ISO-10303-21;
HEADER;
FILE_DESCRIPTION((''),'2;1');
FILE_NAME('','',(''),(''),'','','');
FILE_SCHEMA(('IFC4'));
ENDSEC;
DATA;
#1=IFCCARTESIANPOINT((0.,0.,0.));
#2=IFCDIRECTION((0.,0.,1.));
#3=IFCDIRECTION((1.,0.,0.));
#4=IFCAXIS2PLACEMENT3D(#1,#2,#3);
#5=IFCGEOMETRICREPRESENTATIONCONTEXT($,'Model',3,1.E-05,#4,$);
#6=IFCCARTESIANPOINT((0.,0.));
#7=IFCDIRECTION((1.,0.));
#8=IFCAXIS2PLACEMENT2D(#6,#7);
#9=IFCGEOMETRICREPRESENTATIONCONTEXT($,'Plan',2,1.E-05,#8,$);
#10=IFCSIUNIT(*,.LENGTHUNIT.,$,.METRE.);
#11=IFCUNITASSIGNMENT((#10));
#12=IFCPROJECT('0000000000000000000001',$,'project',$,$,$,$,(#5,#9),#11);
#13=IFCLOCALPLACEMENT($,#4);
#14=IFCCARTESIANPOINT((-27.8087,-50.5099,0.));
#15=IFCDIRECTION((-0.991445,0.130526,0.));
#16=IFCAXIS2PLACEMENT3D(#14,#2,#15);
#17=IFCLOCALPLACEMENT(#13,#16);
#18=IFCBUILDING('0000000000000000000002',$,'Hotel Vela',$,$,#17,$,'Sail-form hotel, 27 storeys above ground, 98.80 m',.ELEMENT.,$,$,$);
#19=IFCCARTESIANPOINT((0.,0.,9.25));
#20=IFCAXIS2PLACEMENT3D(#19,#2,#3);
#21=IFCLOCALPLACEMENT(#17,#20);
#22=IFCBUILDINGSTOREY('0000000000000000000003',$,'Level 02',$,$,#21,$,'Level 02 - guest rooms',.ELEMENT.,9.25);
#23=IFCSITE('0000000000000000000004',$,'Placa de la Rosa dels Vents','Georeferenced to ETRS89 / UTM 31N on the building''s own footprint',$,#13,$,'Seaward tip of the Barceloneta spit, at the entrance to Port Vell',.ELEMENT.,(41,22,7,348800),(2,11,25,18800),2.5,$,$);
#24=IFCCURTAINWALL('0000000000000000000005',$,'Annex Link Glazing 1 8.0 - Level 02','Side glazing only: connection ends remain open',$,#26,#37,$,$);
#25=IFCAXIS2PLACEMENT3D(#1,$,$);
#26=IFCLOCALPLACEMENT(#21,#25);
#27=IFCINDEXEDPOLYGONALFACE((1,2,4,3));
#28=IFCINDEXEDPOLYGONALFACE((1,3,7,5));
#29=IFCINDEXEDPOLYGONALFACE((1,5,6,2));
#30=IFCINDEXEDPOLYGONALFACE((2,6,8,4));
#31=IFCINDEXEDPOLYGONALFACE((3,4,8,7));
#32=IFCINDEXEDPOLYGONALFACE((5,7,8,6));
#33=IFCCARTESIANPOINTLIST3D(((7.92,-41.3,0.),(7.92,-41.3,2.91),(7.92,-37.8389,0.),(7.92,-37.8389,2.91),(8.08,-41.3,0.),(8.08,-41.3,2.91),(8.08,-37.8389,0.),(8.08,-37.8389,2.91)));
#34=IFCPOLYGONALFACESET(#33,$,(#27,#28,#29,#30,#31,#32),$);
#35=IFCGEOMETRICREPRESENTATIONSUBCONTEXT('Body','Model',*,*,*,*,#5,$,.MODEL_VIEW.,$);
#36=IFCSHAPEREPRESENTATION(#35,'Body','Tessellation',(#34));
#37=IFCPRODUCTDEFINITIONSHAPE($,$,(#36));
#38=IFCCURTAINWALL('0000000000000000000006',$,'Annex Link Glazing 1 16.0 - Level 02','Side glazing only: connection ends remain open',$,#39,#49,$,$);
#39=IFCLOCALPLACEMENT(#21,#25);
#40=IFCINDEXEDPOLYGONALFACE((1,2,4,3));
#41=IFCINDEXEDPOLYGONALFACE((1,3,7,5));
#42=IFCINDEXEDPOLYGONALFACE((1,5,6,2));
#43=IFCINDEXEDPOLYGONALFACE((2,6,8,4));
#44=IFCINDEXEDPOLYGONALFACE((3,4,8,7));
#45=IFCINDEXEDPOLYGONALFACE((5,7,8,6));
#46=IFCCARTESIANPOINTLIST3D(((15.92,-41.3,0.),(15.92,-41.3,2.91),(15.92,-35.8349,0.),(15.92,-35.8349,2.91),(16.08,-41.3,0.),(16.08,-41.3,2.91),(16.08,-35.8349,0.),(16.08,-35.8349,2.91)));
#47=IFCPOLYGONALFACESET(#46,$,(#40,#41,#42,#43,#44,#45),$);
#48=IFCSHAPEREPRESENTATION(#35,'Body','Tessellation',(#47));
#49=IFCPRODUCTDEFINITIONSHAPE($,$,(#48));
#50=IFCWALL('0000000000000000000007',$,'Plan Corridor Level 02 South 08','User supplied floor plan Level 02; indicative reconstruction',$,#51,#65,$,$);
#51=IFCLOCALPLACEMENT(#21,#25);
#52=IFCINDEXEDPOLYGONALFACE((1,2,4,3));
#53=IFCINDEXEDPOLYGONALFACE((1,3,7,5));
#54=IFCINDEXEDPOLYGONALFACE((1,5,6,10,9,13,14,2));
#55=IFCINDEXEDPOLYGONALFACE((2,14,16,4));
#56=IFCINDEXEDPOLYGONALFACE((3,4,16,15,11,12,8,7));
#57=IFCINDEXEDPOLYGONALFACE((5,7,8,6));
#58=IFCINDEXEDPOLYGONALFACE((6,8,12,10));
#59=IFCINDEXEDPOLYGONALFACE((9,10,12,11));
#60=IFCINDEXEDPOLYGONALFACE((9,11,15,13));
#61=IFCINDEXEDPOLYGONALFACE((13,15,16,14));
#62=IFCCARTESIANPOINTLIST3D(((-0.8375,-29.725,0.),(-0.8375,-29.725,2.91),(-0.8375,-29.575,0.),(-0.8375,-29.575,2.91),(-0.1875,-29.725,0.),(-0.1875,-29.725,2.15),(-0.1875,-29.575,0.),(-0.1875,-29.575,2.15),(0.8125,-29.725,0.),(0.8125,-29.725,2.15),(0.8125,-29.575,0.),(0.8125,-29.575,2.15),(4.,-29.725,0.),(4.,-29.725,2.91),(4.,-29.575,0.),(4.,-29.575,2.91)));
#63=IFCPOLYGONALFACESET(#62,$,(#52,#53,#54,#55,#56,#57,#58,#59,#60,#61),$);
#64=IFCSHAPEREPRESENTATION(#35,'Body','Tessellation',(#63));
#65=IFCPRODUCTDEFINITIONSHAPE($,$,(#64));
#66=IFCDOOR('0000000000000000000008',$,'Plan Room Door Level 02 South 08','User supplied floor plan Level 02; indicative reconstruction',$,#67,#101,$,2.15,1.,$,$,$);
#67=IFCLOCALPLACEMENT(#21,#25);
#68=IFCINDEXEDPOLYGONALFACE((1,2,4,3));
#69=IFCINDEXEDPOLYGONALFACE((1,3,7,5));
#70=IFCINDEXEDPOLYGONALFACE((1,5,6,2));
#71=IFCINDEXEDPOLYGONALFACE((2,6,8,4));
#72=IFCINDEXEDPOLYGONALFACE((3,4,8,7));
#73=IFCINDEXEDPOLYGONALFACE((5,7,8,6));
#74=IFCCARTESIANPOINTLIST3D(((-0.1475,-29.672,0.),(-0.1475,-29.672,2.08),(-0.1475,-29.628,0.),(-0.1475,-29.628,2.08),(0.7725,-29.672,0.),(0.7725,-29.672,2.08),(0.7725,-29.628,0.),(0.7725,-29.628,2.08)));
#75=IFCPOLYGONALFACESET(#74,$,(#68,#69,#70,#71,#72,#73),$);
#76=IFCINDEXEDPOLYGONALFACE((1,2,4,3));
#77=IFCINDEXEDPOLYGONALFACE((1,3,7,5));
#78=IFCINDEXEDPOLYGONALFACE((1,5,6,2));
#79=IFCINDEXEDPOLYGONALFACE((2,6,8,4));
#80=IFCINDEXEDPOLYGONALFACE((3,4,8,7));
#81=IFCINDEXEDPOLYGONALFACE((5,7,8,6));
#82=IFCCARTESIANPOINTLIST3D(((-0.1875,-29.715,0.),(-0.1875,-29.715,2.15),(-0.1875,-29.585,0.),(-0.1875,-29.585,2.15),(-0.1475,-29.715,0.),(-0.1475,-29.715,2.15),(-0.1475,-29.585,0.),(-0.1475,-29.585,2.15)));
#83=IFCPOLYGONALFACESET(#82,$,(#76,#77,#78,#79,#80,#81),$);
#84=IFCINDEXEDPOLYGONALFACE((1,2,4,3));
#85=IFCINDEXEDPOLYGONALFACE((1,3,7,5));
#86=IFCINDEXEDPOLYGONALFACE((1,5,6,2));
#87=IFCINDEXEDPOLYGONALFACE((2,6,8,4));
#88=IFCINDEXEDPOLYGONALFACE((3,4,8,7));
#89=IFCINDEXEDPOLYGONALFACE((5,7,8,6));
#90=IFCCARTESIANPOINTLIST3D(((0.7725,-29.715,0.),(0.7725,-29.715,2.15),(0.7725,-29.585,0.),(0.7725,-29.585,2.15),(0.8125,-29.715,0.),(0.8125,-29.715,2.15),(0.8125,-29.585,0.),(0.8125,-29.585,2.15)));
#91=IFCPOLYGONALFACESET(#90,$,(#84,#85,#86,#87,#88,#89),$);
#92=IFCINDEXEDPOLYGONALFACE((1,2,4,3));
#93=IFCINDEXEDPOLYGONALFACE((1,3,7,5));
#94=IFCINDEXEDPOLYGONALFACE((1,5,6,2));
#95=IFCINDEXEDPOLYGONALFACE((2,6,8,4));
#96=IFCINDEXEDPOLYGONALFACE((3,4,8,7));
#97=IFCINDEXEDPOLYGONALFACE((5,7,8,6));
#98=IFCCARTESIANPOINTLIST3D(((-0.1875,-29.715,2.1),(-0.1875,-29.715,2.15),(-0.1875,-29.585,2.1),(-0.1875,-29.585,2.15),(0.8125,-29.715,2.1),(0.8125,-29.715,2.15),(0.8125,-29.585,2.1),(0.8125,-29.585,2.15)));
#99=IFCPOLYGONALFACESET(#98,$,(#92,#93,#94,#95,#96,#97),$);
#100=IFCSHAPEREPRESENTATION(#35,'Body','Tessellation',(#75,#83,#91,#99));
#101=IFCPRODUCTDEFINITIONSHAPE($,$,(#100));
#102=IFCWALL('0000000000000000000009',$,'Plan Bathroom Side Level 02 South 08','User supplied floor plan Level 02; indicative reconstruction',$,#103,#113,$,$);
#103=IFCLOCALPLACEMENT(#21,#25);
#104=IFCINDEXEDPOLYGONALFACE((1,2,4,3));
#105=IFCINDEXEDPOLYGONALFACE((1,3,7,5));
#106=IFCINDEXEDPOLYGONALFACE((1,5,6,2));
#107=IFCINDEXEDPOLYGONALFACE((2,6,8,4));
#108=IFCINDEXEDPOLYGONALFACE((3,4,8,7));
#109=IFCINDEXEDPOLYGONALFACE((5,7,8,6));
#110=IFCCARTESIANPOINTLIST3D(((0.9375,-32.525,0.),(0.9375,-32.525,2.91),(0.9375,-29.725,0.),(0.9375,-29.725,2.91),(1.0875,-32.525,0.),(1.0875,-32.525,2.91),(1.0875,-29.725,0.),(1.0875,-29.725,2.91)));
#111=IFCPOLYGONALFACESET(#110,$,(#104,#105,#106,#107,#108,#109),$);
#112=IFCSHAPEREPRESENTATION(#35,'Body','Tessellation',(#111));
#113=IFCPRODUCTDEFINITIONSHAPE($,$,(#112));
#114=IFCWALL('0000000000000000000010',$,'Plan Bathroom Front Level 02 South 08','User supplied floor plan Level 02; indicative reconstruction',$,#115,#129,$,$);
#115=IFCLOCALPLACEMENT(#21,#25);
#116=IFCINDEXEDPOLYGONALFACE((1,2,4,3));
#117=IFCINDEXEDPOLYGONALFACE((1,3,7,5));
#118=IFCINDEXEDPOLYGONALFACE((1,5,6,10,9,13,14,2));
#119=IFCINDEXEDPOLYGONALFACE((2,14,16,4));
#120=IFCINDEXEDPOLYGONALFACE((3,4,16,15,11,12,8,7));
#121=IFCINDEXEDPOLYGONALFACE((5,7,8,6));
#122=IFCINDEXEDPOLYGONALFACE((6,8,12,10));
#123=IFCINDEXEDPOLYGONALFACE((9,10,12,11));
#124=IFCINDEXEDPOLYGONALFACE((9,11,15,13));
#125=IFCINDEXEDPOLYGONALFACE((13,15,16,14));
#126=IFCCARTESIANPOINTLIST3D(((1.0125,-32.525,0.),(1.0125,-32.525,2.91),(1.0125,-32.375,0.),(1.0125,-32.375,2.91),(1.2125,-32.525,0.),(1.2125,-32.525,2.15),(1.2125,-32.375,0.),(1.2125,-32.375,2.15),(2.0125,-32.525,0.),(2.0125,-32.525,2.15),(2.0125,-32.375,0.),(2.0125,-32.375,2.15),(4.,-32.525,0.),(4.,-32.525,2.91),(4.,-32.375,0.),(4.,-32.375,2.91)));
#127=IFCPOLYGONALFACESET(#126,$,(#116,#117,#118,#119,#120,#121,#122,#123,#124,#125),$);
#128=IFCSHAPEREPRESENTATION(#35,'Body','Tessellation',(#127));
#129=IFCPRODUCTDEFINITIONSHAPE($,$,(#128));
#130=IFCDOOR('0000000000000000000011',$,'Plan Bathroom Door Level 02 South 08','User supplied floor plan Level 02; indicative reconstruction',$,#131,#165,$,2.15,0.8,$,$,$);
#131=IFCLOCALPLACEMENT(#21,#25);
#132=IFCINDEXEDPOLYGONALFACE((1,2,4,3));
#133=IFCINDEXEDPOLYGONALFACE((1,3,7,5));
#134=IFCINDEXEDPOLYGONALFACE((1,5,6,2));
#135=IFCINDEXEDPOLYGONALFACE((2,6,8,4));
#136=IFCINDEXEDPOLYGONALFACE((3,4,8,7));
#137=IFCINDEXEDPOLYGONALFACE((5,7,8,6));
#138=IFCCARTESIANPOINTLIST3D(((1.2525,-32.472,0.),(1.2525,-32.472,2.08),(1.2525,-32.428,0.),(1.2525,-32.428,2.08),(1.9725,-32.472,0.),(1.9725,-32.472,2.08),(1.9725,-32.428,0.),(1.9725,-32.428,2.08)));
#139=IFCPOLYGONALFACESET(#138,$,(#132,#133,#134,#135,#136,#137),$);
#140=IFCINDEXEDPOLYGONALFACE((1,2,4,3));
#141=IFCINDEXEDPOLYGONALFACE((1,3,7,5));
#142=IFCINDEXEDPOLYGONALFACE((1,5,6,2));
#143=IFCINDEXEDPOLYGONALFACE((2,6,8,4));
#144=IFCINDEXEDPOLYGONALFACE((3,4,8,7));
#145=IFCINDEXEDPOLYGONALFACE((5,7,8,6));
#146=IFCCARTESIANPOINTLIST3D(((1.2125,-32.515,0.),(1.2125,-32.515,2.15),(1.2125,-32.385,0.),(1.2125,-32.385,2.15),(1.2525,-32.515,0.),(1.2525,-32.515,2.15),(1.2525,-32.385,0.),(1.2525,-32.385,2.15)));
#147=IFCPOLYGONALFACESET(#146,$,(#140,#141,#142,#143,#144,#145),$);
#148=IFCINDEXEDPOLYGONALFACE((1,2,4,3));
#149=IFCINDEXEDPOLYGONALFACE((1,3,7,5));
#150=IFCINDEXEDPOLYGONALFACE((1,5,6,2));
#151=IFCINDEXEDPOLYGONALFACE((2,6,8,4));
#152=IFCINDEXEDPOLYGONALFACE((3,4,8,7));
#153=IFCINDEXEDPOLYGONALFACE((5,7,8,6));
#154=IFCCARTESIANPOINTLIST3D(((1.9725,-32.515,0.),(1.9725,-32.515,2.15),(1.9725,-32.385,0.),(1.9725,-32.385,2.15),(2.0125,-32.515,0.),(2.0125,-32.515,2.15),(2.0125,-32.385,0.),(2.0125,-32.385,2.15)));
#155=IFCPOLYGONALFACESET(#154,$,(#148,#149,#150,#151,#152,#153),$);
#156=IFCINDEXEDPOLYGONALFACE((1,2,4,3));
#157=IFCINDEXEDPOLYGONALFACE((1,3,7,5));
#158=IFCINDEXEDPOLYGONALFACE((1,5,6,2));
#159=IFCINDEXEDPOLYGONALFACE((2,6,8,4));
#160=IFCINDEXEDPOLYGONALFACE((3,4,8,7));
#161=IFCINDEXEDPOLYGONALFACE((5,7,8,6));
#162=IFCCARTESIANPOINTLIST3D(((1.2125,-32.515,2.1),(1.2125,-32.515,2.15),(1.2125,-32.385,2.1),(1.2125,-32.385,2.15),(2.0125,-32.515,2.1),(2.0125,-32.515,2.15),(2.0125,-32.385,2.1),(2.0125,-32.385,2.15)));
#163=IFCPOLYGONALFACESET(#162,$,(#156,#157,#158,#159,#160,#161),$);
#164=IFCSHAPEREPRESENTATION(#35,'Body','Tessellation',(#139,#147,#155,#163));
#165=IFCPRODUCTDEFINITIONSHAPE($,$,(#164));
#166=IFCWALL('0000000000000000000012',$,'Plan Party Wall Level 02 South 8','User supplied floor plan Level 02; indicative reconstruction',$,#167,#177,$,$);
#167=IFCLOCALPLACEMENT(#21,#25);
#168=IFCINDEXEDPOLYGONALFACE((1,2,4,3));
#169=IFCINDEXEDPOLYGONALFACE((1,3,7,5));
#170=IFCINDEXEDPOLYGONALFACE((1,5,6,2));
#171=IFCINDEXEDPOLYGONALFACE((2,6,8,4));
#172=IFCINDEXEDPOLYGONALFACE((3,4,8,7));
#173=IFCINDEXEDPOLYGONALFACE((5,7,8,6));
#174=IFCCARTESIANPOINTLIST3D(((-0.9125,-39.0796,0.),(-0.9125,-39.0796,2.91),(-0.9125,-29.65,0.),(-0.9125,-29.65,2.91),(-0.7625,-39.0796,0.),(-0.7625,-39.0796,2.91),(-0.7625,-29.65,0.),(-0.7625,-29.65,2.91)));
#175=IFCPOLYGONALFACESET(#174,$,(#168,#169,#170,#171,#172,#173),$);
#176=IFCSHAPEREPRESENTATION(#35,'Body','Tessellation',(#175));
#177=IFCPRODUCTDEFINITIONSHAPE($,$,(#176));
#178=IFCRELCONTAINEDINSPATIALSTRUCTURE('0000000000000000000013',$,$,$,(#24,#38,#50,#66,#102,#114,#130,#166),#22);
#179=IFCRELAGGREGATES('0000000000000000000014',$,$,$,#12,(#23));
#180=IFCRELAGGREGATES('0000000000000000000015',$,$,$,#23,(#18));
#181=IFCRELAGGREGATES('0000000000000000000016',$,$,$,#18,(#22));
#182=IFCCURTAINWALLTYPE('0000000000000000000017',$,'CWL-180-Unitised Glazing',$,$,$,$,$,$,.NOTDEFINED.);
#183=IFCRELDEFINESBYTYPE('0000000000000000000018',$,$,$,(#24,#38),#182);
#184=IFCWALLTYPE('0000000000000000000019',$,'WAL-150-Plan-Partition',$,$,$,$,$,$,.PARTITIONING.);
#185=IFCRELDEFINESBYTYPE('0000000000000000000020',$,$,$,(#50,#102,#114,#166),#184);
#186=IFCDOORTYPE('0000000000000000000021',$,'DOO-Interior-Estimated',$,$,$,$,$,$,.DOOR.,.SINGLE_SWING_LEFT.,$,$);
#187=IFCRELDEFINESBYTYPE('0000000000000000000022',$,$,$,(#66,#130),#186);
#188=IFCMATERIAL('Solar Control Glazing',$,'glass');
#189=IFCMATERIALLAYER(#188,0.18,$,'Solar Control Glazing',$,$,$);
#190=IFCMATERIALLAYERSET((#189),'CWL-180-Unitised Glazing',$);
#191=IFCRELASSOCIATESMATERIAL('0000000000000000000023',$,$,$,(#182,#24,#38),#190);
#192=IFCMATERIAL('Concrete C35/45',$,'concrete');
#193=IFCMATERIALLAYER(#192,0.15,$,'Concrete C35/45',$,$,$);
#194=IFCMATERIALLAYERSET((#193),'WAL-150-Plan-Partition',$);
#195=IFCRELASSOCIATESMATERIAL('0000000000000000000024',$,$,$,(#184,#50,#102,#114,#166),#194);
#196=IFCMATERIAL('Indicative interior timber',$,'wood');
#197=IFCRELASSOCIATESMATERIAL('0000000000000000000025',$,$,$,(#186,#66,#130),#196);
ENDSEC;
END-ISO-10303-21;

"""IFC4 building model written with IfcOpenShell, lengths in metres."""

from ifc_helpers import new_model, si_unit, frame, origin_with_axes, origin_2d_with_axis, place, context, subcontext, project, spatial, line, indexed_curve, outline, extrude, material, layer, layer_set, layer_usage, type_object, element, fill, save


model = new_model("IFC4")

# Units and contexts
model_context = context("Model", 3, precision=1e-05, world=origin_with_axes())
plan_context = context("Plan", 2, precision=1e-05, world=origin_2d_with_axis())
body_context = subcontext(model_context, "Body", "Model", "MODEL_VIEW")
ifc_project = project(units=[si_unit("LENGTHUNIT", "METRE")], contexts=[model_context, plan_context])

# Site, building, storey
site_placement = place(None, origin_with_axes())
site = spatial("IfcSite", under=ifc_project, at=site_placement, Name="Placa de la Rosa dels Vents", Description="Georeferenced to ETRS89 / UTM 31N on the building's own footprint", LongName="Seaward tip of the Barceloneta spit, at the entrance to Port Vell", CompositionType="ELEMENT", RefLatitude=(41, 22, 7, 348800), RefLongitude=(2, 11, 25, 18800), RefElevation=2.5)
building_placement = place(site_placement, frame((-27.8087, -50.5099, 0.0), z_axis=(0.0, 0.0, 1.0), x_axis=(-0.991445, 0.130526, 0.0)))
building = spatial("IfcBuilding", under=site, at=building_placement, Name="Hotel Vela", LongName="Sail-form hotel, 27 storeys above ground, 98.80 m", CompositionType="ELEMENT")
storey_placement = place(building_placement, frame((0.0, 0.0, 9.25), z_axis=(0.0, 0.0, 1.0), x_axis=(1.0, 0.0, 0.0)))
storey = spatial("IfcBuildingStorey", under=building, at=storey_placement, Name="Level 02", LongName="Level 02 - guest rooms", CompositionType="ELEMENT", Elevation=9.25)

# Curtain walls
ifc_material_1 = material(Name="Solar Control Glazing", Category="glass")
ifc_layer_1 = layer(ifc_material_1, 0.18, Name="Solar Control Glazing")
ifc_layer_set_1 = layer_set([ifc_layer_1], Name="CWL-180-Unitised Glazing")
ifc_layer_usage_1 = layer_usage(ifc_layer_set_1, "AXIS2", "POSITIVE", 0.0)
curtain_wall_type = type_object("IfcCurtainWallType", Name="CWL-180-Unitised Glazing", PredefinedType="NOTDEFINED", material=ifc_layer_set_1)
curtain_wall_1_placement = place(storey_placement, frame((7.92, -41.3, 0.0), z_axis=(0.0, 0.0, 1.0), x_axis=(1.0, 0.0, 0.0)))
element("IfcCurtainWall", 1, at=curtain_wall_1_placement, inside=storey, type_object=curtain_wall_type, material=ifc_layer_usage_1, Name="Annex Link Glazing 1 8.0 - Level 02", Description="Side glazing only: connection ends remain open", context=body_context, shape_type="SweptSolid", body=[
    extrude(outline(indexed_curve([(0.0, 0.0), (0.16, 0.0), (0.16, 3.4611), (0.0, 3.4611)], segments=[line(1, 2, 3, 4, 1)])), origin_with_axes(), (0.0, 0.0, 1.0), 2.91),
])
ifc_layer_usage_2 = layer_usage(ifc_layer_set_1, "AXIS2", "POSITIVE", 0.0)
curtain_wall_2_placement = place(storey_placement, frame((15.92, -41.3, 0.0), z_axis=(0.0, 0.0, 1.0), x_axis=(1.0, 0.0, 0.0)))
element("IfcCurtainWall", 2, at=curtain_wall_2_placement, inside=storey, type_object=curtain_wall_type, material=ifc_layer_usage_2, Name="Annex Link Glazing 1 16.0 - Level 02", Description="Side glazing only: connection ends remain open", context=body_context, shape_type="SweptSolid", body=[
    extrude(outline(indexed_curve([(0.0, 0.0), (0.16, 0.0), (0.16, 5.4651), (0.0, 5.4651)], segments=[line(1, 2, 3, 4, 1)])), origin_with_axes(), (0.0, 0.0, 1.0), 2.91),
])

# Wall, opening, door
ifc_material_2 = material(Name="Concrete C35/45", Category="concrete")
ifc_layer_2 = layer(ifc_material_2, 0.15, Name="Concrete C35/45")
ifc_layer_set_2 = layer_set([ifc_layer_2], Name="WAL-150-Plan-Partition")
ifc_layer_usage_3 = layer_usage(ifc_layer_set_2, "AXIS2", "POSITIVE", 0.0)
wall_type = type_object("IfcWallType", Name="WAL-150-Plan-Partition", PredefinedType="PARTITIONING", material=ifc_layer_set_2)
wall_1_placement = place(storey_placement, frame((-0.8375, -29.725, 0.0), z_axis=(0.0, 0.0, 1.0), x_axis=(1.0, 0.0, 0.0)))
wall_1 = element("IfcWall", 3, at=wall_1_placement, inside=storey, type_object=wall_type, material=ifc_layer_usage_3, Name="Plan Corridor Level 02 South 08", Description="User supplied floor plan Level 02; indicative reconstruction", context=body_context, shape_type="SweptSolid", body=[
    extrude(outline(indexed_curve([(0.0, 0.0), (4.8375, 0.0), (4.8375, 0.15), (0.0, 0.15)], segments=[line(1, 2, 3, 4, 1)])), origin_with_axes(), (0.0, 0.0, 1.0), 2.91),
])
opening_1_placement = place(wall_1_placement, frame((0.65, -0.085, 0.0), z_axis=(0.0, 0.0, 1.0), x_axis=(1.0, 0.0, 0.0)))
opening_1 = element("IfcOpeningElement", 4, at=opening_1_placement, cuts=wall_1, PredefinedType="OPENING", context=body_context, shape_type="SweptSolid", body=[
    extrude(outline(indexed_curve([(0.0, 0.0), (1.0, 0.0), (1.0, 0.32), (0.0, 0.32)], segments=[line(1, 2, 3, 4, 1)])), origin_with_axes(), (0.0, 0.0, 1.0), 2.15),
])
ifc_material_3 = material(Name="Indicative interior timber", Category="wood")
door_type = type_object("IfcDoorType", Name="DOO-Interior-Estimated", OperationType="SINGLE_SWING_LEFT", PredefinedType="DOOR", material=ifc_material_3)
door_1_placement = place(storey_placement, frame((0.0, 0.0, -9.25), z_axis=(0.0, 0.0, 1.0), x_axis=(1.0, 0.0, 0.0)))
door_1 = element("IfcDoor", 5, at=door_1_placement, inside=storey, type_object=door_type, material=ifc_material_3, Name="Plan Room Door Level 02 South 08", Description="User supplied floor plan Level 02; indicative reconstruction", OverallHeight=2.15, OverallWidth=1.0, context=body_context, shape_type="SweptSolid", body=[
    extrude(outline(indexed_curve([(0.0, 0.0), (0.92, 0.0), (0.92, 0.044), (0.0, 0.044)], segments=[line(1, 2, 3, 4, 1)])), frame((-0.1475, -29.672, 9.25), z_axis=(0.0, 0.0, 1.0), x_axis=(1.0, 0.0, 0.0)), (0.0, 0.0, 1.0), 2.08),
    extrude(outline(indexed_curve([(0.0, 0.0), (0.04, 0.0), (0.04, 0.13), (0.0, 0.13)], segments=[line(1, 2, 3, 4, 1)])), frame((-0.1875, -29.715, 9.25), z_axis=(0.0, 0.0, 1.0), x_axis=(1.0, 0.0, 0.0)), (0.0, 0.0, 1.0), 2.15),
    extrude(outline(indexed_curve([(0.0, 0.0), (0.04, 0.0), (0.04, 0.13), (0.0, 0.13)], segments=[line(1, 2, 3, 4, 1)])), frame((0.7725, -29.715, 9.25), z_axis=(0.0, 0.0, 1.0), x_axis=(1.0, 0.0, 0.0)), (0.0, 0.0, 1.0), 2.15),
    extrude(outline(indexed_curve([(0.0, 0.0), (1.0, 0.0), (1.0, 0.13), (0.0, 0.13)], segments=[line(1, 2, 3, 4, 1)])), frame((-0.1875, -29.715, 11.35), z_axis=(0.0, 0.0, 1.0), x_axis=(1.0, 0.0, 0.0)), (0.0, 0.0, 1.0), 0.05),
])
fill(opening_1, door_1)

# Wall
ifc_layer_usage_4 = layer_usage(ifc_layer_set_2, "AXIS2", "POSITIVE", 0.0)
wall_2_placement = place(storey_placement, frame((0.9375, -32.525, 0.0), z_axis=(0.0, 0.0, 1.0), x_axis=(1.0, 0.0, 0.0)))
element("IfcWall", 6, at=wall_2_placement, inside=storey, type_object=wall_type, material=ifc_layer_usage_4, Name="Plan Bathroom Side Level 02 South 08", Description="User supplied floor plan Level 02; indicative reconstruction", context=body_context, shape_type="SweptSolid", body=[
    extrude(outline(indexed_curve([(0.0, 0.0), (0.15, 0.0), (0.15, 2.8), (0.0, 2.8)], segments=[line(1, 2, 3, 4, 1)])), origin_with_axes(), (0.0, 0.0, 1.0), 2.91),
])

# Wall, opening, door
ifc_layer_usage_5 = layer_usage(ifc_layer_set_2, "AXIS2", "POSITIVE", 0.0)
wall_3_placement = place(storey_placement, frame((1.0125, -32.525, 0.0), z_axis=(0.0, 0.0, 1.0), x_axis=(1.0, 0.0, 0.0)))
wall_3 = element("IfcWall", 7, at=wall_3_placement, inside=storey, type_object=wall_type, material=ifc_layer_usage_5, Name="Plan Bathroom Front Level 02 South 08", Description="User supplied floor plan Level 02; indicative reconstruction", context=body_context, shape_type="SweptSolid", body=[
    extrude(outline(indexed_curve([(0.0, 0.0), (2.9875, 0.0), (2.9875, 0.15), (0.0, 0.15)], segments=[line(1, 2, 3, 4, 1)])), origin_with_axes(), (0.0, 0.0, 1.0), 2.91),
])
opening_2_placement = place(wall_3_placement, frame((0.2, -0.085, 0.0), z_axis=(0.0, 0.0, 1.0), x_axis=(1.0, 0.0, 0.0)))
opening_2 = element("IfcOpeningElement", 8, at=opening_2_placement, cuts=wall_3, PredefinedType="OPENING", context=body_context, shape_type="SweptSolid", body=[
    extrude(outline(indexed_curve([(0.0, 0.0), (0.8, 0.0), (0.8, 0.32), (0.0, 0.32)], segments=[line(1, 2, 3, 4, 1)])), origin_with_axes(), (0.0, 0.0, 1.0), 2.15),
])
door_2_placement = place(storey_placement, frame((0.0, 0.0, -9.25), z_axis=(0.0, 0.0, 1.0), x_axis=(1.0, 0.0, 0.0)))
door_2 = element("IfcDoor", 9, at=door_2_placement, inside=storey, type_object=door_type, material=ifc_material_3, Name="Plan Bathroom Door Level 02 South 08", Description="User supplied floor plan Level 02; indicative reconstruction", OverallHeight=2.15, OverallWidth=0.8, context=body_context, shape_type="SweptSolid", body=[
    extrude(outline(indexed_curve([(0.0, 0.0), (0.72, 0.0), (0.72, 0.044), (0.0, 0.044)], segments=[line(1, 2, 3, 4, 1)])), frame((1.2525, -32.472, 9.25), z_axis=(0.0, 0.0, 1.0), x_axis=(1.0, 0.0, 0.0)), (0.0, 0.0, 1.0), 2.08),
    extrude(outline(indexed_curve([(0.0, 0.0), (0.04, 0.0), (0.04, 0.13), (0.0, 0.13)], segments=[line(1, 2, 3, 4, 1)])), frame((1.2125, -32.515, 9.25), z_axis=(0.0, 0.0, 1.0), x_axis=(1.0, 0.0, 0.0)), (0.0, 0.0, 1.0), 2.15),
    extrude(outline(indexed_curve([(0.0, 0.0), (0.04, 0.0), (0.04, 0.13), (0.0, 0.13)], segments=[line(1, 2, 3, 4, 1)])), frame((1.9725, -32.515, 9.25), z_axis=(0.0, 0.0, 1.0), x_axis=(1.0, 0.0, 0.0)), (0.0, 0.0, 1.0), 2.15),
    extrude(outline(indexed_curve([(0.0, 0.0), (0.8, 0.0), (0.8, 0.13), (0.0, 0.13)], segments=[line(1, 2, 3, 4, 1)])), frame((1.2125, -32.515, 11.35), z_axis=(0.0, 0.0, 1.0), x_axis=(1.0, 0.0, 0.0)), (0.0, 0.0, 1.0), 0.05),
])
fill(opening_2, door_2)

# Wall
ifc_layer_usage_6 = layer_usage(ifc_layer_set_2, "AXIS2", "POSITIVE", 0.0)
wall_4_placement = place(storey_placement, frame((-0.9125, -39.0796, 0.0), z_axis=(0.0, 0.0, 1.0), x_axis=(1.0, 0.0, 0.0)))
element("IfcWall", 10, at=wall_4_placement, inside=storey, type_object=wall_type, material=ifc_layer_usage_6, Name="Plan Party Wall Level 02 South 8", Description="User supplied floor plan Level 02; indicative reconstruction", context=body_context, shape_type="SweptSolid", body=[
    extrude(outline(indexed_curve([(0.0, 0.0), (0.15, 0.0), (0.15, 9.4296), (0.0, 9.4296)], segments=[line(1, 2, 3, 4, 1)])), origin_with_axes(), (0.0, 0.0, 1.0), 2.91),
])

save(model, "model.ifc")
